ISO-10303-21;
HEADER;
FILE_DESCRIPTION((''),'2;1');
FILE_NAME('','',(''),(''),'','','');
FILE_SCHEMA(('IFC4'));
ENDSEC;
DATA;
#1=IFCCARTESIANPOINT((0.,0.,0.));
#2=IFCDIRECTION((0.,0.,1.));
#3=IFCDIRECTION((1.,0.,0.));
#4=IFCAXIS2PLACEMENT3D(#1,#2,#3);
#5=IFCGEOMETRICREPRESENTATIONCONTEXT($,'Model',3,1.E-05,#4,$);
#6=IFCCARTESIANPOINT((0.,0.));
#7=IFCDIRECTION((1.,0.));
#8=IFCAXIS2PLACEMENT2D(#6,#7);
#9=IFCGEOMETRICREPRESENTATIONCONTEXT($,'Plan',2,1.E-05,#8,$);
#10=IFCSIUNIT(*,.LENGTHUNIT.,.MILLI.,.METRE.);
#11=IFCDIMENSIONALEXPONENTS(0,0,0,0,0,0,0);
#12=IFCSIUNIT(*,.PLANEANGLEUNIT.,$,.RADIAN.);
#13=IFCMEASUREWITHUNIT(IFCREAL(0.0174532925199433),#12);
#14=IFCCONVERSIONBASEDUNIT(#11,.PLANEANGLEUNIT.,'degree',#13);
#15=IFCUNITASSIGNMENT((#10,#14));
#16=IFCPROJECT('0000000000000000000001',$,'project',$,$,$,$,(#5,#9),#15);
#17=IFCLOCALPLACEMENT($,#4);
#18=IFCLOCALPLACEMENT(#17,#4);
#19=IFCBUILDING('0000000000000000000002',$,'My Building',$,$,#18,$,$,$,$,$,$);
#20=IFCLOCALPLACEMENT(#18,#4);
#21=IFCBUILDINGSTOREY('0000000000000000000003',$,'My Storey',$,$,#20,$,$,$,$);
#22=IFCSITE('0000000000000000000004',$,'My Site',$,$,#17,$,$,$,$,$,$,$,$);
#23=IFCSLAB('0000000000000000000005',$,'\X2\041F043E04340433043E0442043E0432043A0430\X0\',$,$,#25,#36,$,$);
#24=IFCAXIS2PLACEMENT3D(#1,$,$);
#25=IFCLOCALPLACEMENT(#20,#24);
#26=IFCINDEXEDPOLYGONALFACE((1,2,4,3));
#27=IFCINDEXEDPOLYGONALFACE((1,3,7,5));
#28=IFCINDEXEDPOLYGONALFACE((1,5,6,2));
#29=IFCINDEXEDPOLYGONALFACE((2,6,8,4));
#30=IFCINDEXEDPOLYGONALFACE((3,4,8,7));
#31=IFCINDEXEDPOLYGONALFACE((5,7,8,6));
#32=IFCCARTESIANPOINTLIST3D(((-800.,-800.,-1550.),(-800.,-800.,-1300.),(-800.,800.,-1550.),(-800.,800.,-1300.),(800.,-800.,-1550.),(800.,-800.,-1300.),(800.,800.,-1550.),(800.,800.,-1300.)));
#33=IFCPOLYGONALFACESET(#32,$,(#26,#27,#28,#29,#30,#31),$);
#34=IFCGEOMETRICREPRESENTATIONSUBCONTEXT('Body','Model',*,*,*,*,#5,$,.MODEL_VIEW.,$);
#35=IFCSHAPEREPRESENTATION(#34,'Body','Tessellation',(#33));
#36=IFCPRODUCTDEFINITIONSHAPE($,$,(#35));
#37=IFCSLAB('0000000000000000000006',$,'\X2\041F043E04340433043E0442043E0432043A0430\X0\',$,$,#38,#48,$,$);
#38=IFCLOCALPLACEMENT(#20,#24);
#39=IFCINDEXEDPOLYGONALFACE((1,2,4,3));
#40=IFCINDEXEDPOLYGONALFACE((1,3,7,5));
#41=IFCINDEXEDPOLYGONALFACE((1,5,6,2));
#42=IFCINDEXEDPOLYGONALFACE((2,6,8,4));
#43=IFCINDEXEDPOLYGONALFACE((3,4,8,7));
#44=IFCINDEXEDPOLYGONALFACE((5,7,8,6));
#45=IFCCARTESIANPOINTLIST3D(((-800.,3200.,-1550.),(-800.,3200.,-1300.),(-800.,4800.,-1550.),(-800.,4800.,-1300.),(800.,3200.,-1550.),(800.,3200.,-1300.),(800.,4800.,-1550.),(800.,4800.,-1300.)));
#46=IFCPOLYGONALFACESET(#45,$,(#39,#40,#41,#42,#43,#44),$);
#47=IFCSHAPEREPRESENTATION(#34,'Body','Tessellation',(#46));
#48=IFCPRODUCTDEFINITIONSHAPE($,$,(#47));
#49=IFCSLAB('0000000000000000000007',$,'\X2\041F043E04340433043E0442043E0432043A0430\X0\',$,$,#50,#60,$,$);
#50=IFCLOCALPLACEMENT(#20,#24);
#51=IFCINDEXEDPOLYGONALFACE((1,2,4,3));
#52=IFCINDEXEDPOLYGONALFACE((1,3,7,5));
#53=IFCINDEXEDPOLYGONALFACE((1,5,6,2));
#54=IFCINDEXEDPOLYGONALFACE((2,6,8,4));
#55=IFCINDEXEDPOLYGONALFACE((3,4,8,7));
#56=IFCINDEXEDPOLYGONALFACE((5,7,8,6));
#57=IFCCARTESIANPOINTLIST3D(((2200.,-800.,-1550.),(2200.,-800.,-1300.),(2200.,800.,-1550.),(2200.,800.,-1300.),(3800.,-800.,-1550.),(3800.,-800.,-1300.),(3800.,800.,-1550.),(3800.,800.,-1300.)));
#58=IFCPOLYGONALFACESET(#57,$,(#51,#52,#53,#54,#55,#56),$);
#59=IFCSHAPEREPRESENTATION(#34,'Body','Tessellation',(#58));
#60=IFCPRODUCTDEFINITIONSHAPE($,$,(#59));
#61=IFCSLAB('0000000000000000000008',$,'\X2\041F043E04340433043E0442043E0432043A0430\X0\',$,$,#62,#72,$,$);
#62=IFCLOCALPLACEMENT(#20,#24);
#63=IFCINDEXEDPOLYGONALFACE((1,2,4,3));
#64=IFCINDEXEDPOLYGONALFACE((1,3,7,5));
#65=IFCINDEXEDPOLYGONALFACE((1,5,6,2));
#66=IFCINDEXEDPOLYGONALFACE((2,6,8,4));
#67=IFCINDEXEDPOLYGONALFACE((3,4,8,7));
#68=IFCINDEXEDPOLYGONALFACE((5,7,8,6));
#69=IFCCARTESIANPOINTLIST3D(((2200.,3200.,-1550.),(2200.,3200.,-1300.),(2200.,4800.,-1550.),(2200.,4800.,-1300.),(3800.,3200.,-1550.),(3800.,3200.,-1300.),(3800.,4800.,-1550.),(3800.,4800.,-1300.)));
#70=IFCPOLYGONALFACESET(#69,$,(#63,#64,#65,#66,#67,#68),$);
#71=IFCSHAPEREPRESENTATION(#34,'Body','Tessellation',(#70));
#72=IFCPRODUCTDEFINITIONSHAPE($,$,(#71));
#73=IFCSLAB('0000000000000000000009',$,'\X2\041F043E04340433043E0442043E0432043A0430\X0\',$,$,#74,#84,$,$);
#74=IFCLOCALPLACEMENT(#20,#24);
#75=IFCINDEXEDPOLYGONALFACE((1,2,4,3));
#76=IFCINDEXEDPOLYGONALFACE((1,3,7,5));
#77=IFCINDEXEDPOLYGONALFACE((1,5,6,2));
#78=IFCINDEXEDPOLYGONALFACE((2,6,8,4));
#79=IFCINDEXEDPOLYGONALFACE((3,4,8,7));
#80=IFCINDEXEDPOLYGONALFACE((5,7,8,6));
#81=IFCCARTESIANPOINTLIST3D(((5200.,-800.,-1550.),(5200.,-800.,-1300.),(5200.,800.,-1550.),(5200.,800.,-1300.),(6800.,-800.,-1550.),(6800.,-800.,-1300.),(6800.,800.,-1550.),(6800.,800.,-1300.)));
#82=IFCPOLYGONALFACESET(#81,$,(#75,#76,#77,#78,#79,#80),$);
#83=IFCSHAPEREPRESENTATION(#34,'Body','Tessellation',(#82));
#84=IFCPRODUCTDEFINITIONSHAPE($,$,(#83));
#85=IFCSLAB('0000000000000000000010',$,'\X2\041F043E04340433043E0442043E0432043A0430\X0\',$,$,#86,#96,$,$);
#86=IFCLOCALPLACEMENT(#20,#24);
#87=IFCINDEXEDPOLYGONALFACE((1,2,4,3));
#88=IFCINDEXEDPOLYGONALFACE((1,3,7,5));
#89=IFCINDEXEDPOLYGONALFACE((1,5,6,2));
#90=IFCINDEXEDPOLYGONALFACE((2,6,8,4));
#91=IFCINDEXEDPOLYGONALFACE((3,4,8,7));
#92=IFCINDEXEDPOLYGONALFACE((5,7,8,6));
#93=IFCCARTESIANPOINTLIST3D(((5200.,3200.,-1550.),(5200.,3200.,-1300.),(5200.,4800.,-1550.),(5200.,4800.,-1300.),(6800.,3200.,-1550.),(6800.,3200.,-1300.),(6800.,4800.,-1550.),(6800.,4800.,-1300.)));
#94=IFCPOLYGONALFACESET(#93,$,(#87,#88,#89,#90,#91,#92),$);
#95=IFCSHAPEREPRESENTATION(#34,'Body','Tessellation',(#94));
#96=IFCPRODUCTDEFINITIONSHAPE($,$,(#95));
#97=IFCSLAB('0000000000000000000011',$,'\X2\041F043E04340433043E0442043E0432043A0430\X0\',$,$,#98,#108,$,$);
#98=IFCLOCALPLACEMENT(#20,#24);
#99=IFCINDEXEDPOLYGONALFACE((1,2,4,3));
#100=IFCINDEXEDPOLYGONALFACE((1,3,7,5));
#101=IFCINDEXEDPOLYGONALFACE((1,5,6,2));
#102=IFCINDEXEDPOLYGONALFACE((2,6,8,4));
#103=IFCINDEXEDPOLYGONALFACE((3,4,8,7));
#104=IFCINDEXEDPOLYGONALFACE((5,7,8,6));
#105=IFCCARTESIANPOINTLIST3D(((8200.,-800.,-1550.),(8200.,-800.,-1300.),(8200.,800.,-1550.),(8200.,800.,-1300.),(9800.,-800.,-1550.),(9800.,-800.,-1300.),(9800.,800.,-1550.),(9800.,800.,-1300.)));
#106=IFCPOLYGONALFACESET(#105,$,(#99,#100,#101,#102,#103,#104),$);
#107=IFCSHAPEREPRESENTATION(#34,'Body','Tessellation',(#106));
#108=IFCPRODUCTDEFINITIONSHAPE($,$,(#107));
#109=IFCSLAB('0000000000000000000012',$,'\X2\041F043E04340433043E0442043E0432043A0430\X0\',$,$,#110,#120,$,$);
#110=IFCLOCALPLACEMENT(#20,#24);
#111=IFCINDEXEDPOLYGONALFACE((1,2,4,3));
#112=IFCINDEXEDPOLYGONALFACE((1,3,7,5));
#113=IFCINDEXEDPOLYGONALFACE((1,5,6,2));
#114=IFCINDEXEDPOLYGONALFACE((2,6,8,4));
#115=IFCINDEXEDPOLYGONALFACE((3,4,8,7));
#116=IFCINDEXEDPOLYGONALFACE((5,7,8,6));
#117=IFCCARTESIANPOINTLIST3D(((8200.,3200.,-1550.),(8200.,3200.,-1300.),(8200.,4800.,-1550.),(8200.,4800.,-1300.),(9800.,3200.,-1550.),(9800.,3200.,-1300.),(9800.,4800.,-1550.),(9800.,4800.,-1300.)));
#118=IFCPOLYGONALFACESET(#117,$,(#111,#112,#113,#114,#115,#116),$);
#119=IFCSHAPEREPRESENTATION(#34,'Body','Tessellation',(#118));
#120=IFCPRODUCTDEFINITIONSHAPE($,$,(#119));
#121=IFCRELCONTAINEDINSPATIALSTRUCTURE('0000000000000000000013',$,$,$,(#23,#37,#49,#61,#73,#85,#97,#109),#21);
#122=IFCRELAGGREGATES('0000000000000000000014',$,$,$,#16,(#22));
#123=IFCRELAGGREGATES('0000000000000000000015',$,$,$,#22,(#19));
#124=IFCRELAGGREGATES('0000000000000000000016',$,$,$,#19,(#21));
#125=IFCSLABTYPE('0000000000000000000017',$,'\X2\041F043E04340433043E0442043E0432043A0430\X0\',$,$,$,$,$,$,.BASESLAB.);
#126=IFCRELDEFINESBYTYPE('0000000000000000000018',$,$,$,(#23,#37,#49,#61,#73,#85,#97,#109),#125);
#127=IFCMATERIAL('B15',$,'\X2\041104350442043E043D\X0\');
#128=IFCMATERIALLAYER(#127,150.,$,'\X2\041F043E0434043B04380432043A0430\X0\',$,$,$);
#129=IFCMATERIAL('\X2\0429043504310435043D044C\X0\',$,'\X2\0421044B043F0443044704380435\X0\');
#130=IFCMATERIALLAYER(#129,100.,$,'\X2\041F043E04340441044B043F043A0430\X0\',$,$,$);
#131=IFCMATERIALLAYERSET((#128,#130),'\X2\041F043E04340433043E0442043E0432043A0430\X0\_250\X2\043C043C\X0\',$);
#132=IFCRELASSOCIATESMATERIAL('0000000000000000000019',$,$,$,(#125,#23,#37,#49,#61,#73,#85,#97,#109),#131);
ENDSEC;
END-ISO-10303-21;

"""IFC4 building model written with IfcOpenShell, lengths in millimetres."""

from ifc_helpers import new_model, entity, si_unit, converted_unit, frame, origin_with_axes, origin_2d_with_axis, place, context, subcontext, project, spatial, line, indexed_curve, outline, extrude, material, layer, layer_set, layer_usage, type_object, element, save


model = new_model("IFC4")

# Units and contexts
model_context = context("Model", 3, precision=1e-05, world=origin_with_axes())
plan_context = context("Plan", 2, precision=1e-05, world=origin_2d_with_axis())
body_context = subcontext(model_context, "Body", "Model", "MODEL_VIEW")
ifc_project = project(units=[si_unit("LENGTHUNIT", "METRE", prefix="MILLI"), converted_unit("PLANEANGLEUNIT", "degree", entity("IfcReal", 0.0174532925199433), si_unit("PLANEANGLEUNIT", "RADIAN"), dimensions=[0, 0, 0, 0, 0, 0, 0])], contexts=[model_context, plan_context])

# Site, building, storey
site_placement = place(None, origin_with_axes())
site = spatial("IfcSite", under=ifc_project, at=site_placement, Name="My Site")
building_placement = place(site_placement, origin_with_axes())
building = spatial("IfcBuilding", under=site, at=building_placement, Name="My Building")
storey_placement = place(building_placement, origin_with_axes())
storey = spatial("IfcBuildingStorey", under=building, at=storey_placement, Name="My Storey")

# Slabs
ifc_material_1 = material(Name="B15", Category="Бетон")
ifc_layer_1 = layer(ifc_material_1, 150.0, Name="Подливка")
ifc_material_2 = material(Name="Щебень", Category="Сыпучие")
ifc_layer_2 = layer(ifc_material_2, 100.0, Name="Подсыпка")
ifc_layer_set = layer_set([ifc_layer_1, ifc_layer_2], Name="Подготовка_250мм")
ifc_layer_usage_1 = layer_usage(ifc_layer_set, "AXIS3", "NEGATIVE", 0.0)
slab_type = type_object("IfcSlabType", Name="Подготовка", PredefinedType="BASESLAB", material=ifc_layer_set)
slab_1_placement = place(storey_placement, frame((0.0, 0.0, -1550.0), z_axis=(0.0, 0.0, 1.0), x_axis=(1.0, 0.0, 0.0)))
element("IfcSlab", 1, at=slab_1_placement, inside=storey, type_object=slab_type, material=ifc_layer_usage_1, Name="Подготовка", context=body_context, shape_type="SweptSolid", body=[
    extrude(outline(indexed_curve([(800.0, 800.0), (800.0, -800.0), (-800.0, -800.0), (-800.0, 800.0)], segments=[line(3, 2), line(2, 1), line(1, 4), line(4, 3)], self_intersect=False)), None, (0.0, 0.0, 1.0), 250.0),
])
ifc_layer_usage_2 = layer_usage(ifc_layer_set, "AXIS3", "NEGATIVE", 0.0)
slab_2_placement = place(storey_placement, frame((0.0, 4000.0, -1550.0), z_axis=(0.0, 0.0, 1.0), x_axis=(1.0, 0.0, 0.0)))
element("IfcSlab", 2, at=slab_2_placement, inside=storey, type_object=slab_type, material=ifc_layer_usage_2, Name="Подготовка", context=body_context, shape_type="SweptSolid", body=[
    extrude(outline(indexed_curve([(800.0, 800.0), (800.0, -800.0), (-800.0, -800.0), (-800.0, 800.0)], segments=[line(3, 2), line(2, 1), line(1, 4), line(4, 3)], self_intersect=False)), None, (0.0, 0.0, 1.0), 250.0),
])
ifc_layer_usage_3 = layer_usage(ifc_layer_set, "AXIS3", "NEGATIVE", 0.0)
slab_3_placement = place(storey_placement, frame((3000.0, 0.0, -1550.0), z_axis=(0.0, 0.0, 1.0), x_axis=(1.0, 0.0, 0.0)))
element("IfcSlab", 3, at=slab_3_placement, inside=storey, type_object=slab_type, material=ifc_layer_usage_3, Name="Подготовка", context=body_context, shape_type="SweptSolid", body=[
    extrude(outline(indexed_curve([(800.0, 800.0), (800.0, -800.0), (-800.0, -800.0), (-800.0, 800.0)], segments=[line(3, 2), line(2, 1), line(1, 4), line(4, 3)], self_intersect=False)), None, (0.0, 0.0, 1.0), 250.0),
])
ifc_layer_usage_4 = layer_usage(ifc_layer_set, "AXIS3", "NEGATIVE", 0.0)
slab_4_placement = place(storey_placement, frame((3000.0, 4000.0, -1550.0), z_axis=(0.0, 0.0, 1.0), x_axis=(1.0, 0.0, 0.0)))
element("IfcSlab", 4, at=slab_4_placement, inside=storey, type_object=slab_type, material=ifc_layer_usage_4, Name="Подготовка", context=body_context, shape_type="SweptSolid", body=[
    extrude(outline(indexed_curve([(800.0, 800.0), (800.0, -800.0), (-800.0, -800.0), (-800.0, 800.0)], segments=[line(3, 2), line(2, 1), line(1, 4), line(4, 3)], self_intersect=False)), None, (0.0, 0.0, 1.0), 250.0),
])
ifc_layer_usage_5 = layer_usage(ifc_layer_set, "AXIS3", "NEGATIVE", 0.0)
slab_5_placement = place(storey_placement, frame((6000.0, 0.0, -1550.0), z_axis=(0.0, 0.0, 1.0), x_axis=(1.0, 0.0, 0.0)))
element("IfcSlab", 5, at=slab_5_placement, inside=storey, type_object=slab_type, material=ifc_layer_usage_5, Name="Подготовка", context=body_context, shape_type="SweptSolid", body=[
    extrude(outline(indexed_curve([(800.0, 800.0), (800.0, -800.0), (-800.0, -800.0), (-800.0, 800.0)], segments=[line(3, 2), line(2, 1), line(1, 4), line(4, 3)], self_intersect=False)), None, (0.0, 0.0, 1.0), 250.0),
])
ifc_layer_usage_6 = layer_usage(ifc_layer_set, "AXIS3", "NEGATIVE", 0.0)
slab_6_placement = place(storey_placement, frame((6000.0, 4000.0, -1550.0), z_axis=(0.0, 0.0, 1.0), x_axis=(1.0, 0.0, 0.0)))
element("IfcSlab", 6, at=slab_6_placement, inside=storey, type_object=slab_type, material=ifc_layer_usage_6, Name="Подготовка", context=body_context, shape_type="SweptSolid", body=[
    extrude(outline(indexed_curve([(800.0, 800.0), (800.0, -800.0), (-800.0, -800.0), (-800.0, 800.0)], segments=[line(3, 2), line(2, 1), line(1, 4), line(4, 3)], self_intersect=False)), None, (0.0, 0.0, 1.0), 250.0),
])
ifc_layer_usage_7 = layer_usage(ifc_layer_set, "AXIS3", "NEGATIVE", 0.0)
slab_7_placement = place(storey_placement, frame((9000.0, 0.0, -1550.0), z_axis=(0.0, 0.0, 1.0), x_axis=(1.0, 0.0, 0.0)))
element("IfcSlab", 7, at=slab_7_placement, inside=storey, type_object=slab_type, material=ifc_layer_usage_7, Name="Подготовка", context=body_context, shape_type="SweptSolid", body=[
    extrude(outline(indexed_curve([(800.0, 800.0), (800.0, -800.0), (-800.0, -800.0), (-800.0, 800.0)], segments=[line(3, 2), line(2, 1), line(1, 4), line(4, 3)], self_intersect=False)), None, (0.0, 0.0, 1.0), 250.0),
])
ifc_layer_usage_8 = layer_usage(ifc_layer_set, "AXIS3", "NEGATIVE", 0.0)
slab_8_placement = place(storey_placement, frame((9000.0, 4000.0, -1550.0), z_axis=(0.0, 0.0, 1.0), x_axis=(1.0, 0.0, 0.0)))
element("IfcSlab", 8, at=slab_8_placement, inside=storey, type_object=slab_type, material=ifc_layer_usage_8, Name="Подготовка", context=body_context, shape_type="SweptSolid", body=[
    extrude(outline(indexed_curve([(800.0, 800.0), (800.0, -800.0), (-800.0, -800.0), (-800.0, 800.0)], segments=[line(3, 2), line(2, 1), line(1, 4), line(4, 3)], self_intersect=False)), None, (0.0, 0.0, 1.0), 250.0),
])

save(model, "model.ifc")
